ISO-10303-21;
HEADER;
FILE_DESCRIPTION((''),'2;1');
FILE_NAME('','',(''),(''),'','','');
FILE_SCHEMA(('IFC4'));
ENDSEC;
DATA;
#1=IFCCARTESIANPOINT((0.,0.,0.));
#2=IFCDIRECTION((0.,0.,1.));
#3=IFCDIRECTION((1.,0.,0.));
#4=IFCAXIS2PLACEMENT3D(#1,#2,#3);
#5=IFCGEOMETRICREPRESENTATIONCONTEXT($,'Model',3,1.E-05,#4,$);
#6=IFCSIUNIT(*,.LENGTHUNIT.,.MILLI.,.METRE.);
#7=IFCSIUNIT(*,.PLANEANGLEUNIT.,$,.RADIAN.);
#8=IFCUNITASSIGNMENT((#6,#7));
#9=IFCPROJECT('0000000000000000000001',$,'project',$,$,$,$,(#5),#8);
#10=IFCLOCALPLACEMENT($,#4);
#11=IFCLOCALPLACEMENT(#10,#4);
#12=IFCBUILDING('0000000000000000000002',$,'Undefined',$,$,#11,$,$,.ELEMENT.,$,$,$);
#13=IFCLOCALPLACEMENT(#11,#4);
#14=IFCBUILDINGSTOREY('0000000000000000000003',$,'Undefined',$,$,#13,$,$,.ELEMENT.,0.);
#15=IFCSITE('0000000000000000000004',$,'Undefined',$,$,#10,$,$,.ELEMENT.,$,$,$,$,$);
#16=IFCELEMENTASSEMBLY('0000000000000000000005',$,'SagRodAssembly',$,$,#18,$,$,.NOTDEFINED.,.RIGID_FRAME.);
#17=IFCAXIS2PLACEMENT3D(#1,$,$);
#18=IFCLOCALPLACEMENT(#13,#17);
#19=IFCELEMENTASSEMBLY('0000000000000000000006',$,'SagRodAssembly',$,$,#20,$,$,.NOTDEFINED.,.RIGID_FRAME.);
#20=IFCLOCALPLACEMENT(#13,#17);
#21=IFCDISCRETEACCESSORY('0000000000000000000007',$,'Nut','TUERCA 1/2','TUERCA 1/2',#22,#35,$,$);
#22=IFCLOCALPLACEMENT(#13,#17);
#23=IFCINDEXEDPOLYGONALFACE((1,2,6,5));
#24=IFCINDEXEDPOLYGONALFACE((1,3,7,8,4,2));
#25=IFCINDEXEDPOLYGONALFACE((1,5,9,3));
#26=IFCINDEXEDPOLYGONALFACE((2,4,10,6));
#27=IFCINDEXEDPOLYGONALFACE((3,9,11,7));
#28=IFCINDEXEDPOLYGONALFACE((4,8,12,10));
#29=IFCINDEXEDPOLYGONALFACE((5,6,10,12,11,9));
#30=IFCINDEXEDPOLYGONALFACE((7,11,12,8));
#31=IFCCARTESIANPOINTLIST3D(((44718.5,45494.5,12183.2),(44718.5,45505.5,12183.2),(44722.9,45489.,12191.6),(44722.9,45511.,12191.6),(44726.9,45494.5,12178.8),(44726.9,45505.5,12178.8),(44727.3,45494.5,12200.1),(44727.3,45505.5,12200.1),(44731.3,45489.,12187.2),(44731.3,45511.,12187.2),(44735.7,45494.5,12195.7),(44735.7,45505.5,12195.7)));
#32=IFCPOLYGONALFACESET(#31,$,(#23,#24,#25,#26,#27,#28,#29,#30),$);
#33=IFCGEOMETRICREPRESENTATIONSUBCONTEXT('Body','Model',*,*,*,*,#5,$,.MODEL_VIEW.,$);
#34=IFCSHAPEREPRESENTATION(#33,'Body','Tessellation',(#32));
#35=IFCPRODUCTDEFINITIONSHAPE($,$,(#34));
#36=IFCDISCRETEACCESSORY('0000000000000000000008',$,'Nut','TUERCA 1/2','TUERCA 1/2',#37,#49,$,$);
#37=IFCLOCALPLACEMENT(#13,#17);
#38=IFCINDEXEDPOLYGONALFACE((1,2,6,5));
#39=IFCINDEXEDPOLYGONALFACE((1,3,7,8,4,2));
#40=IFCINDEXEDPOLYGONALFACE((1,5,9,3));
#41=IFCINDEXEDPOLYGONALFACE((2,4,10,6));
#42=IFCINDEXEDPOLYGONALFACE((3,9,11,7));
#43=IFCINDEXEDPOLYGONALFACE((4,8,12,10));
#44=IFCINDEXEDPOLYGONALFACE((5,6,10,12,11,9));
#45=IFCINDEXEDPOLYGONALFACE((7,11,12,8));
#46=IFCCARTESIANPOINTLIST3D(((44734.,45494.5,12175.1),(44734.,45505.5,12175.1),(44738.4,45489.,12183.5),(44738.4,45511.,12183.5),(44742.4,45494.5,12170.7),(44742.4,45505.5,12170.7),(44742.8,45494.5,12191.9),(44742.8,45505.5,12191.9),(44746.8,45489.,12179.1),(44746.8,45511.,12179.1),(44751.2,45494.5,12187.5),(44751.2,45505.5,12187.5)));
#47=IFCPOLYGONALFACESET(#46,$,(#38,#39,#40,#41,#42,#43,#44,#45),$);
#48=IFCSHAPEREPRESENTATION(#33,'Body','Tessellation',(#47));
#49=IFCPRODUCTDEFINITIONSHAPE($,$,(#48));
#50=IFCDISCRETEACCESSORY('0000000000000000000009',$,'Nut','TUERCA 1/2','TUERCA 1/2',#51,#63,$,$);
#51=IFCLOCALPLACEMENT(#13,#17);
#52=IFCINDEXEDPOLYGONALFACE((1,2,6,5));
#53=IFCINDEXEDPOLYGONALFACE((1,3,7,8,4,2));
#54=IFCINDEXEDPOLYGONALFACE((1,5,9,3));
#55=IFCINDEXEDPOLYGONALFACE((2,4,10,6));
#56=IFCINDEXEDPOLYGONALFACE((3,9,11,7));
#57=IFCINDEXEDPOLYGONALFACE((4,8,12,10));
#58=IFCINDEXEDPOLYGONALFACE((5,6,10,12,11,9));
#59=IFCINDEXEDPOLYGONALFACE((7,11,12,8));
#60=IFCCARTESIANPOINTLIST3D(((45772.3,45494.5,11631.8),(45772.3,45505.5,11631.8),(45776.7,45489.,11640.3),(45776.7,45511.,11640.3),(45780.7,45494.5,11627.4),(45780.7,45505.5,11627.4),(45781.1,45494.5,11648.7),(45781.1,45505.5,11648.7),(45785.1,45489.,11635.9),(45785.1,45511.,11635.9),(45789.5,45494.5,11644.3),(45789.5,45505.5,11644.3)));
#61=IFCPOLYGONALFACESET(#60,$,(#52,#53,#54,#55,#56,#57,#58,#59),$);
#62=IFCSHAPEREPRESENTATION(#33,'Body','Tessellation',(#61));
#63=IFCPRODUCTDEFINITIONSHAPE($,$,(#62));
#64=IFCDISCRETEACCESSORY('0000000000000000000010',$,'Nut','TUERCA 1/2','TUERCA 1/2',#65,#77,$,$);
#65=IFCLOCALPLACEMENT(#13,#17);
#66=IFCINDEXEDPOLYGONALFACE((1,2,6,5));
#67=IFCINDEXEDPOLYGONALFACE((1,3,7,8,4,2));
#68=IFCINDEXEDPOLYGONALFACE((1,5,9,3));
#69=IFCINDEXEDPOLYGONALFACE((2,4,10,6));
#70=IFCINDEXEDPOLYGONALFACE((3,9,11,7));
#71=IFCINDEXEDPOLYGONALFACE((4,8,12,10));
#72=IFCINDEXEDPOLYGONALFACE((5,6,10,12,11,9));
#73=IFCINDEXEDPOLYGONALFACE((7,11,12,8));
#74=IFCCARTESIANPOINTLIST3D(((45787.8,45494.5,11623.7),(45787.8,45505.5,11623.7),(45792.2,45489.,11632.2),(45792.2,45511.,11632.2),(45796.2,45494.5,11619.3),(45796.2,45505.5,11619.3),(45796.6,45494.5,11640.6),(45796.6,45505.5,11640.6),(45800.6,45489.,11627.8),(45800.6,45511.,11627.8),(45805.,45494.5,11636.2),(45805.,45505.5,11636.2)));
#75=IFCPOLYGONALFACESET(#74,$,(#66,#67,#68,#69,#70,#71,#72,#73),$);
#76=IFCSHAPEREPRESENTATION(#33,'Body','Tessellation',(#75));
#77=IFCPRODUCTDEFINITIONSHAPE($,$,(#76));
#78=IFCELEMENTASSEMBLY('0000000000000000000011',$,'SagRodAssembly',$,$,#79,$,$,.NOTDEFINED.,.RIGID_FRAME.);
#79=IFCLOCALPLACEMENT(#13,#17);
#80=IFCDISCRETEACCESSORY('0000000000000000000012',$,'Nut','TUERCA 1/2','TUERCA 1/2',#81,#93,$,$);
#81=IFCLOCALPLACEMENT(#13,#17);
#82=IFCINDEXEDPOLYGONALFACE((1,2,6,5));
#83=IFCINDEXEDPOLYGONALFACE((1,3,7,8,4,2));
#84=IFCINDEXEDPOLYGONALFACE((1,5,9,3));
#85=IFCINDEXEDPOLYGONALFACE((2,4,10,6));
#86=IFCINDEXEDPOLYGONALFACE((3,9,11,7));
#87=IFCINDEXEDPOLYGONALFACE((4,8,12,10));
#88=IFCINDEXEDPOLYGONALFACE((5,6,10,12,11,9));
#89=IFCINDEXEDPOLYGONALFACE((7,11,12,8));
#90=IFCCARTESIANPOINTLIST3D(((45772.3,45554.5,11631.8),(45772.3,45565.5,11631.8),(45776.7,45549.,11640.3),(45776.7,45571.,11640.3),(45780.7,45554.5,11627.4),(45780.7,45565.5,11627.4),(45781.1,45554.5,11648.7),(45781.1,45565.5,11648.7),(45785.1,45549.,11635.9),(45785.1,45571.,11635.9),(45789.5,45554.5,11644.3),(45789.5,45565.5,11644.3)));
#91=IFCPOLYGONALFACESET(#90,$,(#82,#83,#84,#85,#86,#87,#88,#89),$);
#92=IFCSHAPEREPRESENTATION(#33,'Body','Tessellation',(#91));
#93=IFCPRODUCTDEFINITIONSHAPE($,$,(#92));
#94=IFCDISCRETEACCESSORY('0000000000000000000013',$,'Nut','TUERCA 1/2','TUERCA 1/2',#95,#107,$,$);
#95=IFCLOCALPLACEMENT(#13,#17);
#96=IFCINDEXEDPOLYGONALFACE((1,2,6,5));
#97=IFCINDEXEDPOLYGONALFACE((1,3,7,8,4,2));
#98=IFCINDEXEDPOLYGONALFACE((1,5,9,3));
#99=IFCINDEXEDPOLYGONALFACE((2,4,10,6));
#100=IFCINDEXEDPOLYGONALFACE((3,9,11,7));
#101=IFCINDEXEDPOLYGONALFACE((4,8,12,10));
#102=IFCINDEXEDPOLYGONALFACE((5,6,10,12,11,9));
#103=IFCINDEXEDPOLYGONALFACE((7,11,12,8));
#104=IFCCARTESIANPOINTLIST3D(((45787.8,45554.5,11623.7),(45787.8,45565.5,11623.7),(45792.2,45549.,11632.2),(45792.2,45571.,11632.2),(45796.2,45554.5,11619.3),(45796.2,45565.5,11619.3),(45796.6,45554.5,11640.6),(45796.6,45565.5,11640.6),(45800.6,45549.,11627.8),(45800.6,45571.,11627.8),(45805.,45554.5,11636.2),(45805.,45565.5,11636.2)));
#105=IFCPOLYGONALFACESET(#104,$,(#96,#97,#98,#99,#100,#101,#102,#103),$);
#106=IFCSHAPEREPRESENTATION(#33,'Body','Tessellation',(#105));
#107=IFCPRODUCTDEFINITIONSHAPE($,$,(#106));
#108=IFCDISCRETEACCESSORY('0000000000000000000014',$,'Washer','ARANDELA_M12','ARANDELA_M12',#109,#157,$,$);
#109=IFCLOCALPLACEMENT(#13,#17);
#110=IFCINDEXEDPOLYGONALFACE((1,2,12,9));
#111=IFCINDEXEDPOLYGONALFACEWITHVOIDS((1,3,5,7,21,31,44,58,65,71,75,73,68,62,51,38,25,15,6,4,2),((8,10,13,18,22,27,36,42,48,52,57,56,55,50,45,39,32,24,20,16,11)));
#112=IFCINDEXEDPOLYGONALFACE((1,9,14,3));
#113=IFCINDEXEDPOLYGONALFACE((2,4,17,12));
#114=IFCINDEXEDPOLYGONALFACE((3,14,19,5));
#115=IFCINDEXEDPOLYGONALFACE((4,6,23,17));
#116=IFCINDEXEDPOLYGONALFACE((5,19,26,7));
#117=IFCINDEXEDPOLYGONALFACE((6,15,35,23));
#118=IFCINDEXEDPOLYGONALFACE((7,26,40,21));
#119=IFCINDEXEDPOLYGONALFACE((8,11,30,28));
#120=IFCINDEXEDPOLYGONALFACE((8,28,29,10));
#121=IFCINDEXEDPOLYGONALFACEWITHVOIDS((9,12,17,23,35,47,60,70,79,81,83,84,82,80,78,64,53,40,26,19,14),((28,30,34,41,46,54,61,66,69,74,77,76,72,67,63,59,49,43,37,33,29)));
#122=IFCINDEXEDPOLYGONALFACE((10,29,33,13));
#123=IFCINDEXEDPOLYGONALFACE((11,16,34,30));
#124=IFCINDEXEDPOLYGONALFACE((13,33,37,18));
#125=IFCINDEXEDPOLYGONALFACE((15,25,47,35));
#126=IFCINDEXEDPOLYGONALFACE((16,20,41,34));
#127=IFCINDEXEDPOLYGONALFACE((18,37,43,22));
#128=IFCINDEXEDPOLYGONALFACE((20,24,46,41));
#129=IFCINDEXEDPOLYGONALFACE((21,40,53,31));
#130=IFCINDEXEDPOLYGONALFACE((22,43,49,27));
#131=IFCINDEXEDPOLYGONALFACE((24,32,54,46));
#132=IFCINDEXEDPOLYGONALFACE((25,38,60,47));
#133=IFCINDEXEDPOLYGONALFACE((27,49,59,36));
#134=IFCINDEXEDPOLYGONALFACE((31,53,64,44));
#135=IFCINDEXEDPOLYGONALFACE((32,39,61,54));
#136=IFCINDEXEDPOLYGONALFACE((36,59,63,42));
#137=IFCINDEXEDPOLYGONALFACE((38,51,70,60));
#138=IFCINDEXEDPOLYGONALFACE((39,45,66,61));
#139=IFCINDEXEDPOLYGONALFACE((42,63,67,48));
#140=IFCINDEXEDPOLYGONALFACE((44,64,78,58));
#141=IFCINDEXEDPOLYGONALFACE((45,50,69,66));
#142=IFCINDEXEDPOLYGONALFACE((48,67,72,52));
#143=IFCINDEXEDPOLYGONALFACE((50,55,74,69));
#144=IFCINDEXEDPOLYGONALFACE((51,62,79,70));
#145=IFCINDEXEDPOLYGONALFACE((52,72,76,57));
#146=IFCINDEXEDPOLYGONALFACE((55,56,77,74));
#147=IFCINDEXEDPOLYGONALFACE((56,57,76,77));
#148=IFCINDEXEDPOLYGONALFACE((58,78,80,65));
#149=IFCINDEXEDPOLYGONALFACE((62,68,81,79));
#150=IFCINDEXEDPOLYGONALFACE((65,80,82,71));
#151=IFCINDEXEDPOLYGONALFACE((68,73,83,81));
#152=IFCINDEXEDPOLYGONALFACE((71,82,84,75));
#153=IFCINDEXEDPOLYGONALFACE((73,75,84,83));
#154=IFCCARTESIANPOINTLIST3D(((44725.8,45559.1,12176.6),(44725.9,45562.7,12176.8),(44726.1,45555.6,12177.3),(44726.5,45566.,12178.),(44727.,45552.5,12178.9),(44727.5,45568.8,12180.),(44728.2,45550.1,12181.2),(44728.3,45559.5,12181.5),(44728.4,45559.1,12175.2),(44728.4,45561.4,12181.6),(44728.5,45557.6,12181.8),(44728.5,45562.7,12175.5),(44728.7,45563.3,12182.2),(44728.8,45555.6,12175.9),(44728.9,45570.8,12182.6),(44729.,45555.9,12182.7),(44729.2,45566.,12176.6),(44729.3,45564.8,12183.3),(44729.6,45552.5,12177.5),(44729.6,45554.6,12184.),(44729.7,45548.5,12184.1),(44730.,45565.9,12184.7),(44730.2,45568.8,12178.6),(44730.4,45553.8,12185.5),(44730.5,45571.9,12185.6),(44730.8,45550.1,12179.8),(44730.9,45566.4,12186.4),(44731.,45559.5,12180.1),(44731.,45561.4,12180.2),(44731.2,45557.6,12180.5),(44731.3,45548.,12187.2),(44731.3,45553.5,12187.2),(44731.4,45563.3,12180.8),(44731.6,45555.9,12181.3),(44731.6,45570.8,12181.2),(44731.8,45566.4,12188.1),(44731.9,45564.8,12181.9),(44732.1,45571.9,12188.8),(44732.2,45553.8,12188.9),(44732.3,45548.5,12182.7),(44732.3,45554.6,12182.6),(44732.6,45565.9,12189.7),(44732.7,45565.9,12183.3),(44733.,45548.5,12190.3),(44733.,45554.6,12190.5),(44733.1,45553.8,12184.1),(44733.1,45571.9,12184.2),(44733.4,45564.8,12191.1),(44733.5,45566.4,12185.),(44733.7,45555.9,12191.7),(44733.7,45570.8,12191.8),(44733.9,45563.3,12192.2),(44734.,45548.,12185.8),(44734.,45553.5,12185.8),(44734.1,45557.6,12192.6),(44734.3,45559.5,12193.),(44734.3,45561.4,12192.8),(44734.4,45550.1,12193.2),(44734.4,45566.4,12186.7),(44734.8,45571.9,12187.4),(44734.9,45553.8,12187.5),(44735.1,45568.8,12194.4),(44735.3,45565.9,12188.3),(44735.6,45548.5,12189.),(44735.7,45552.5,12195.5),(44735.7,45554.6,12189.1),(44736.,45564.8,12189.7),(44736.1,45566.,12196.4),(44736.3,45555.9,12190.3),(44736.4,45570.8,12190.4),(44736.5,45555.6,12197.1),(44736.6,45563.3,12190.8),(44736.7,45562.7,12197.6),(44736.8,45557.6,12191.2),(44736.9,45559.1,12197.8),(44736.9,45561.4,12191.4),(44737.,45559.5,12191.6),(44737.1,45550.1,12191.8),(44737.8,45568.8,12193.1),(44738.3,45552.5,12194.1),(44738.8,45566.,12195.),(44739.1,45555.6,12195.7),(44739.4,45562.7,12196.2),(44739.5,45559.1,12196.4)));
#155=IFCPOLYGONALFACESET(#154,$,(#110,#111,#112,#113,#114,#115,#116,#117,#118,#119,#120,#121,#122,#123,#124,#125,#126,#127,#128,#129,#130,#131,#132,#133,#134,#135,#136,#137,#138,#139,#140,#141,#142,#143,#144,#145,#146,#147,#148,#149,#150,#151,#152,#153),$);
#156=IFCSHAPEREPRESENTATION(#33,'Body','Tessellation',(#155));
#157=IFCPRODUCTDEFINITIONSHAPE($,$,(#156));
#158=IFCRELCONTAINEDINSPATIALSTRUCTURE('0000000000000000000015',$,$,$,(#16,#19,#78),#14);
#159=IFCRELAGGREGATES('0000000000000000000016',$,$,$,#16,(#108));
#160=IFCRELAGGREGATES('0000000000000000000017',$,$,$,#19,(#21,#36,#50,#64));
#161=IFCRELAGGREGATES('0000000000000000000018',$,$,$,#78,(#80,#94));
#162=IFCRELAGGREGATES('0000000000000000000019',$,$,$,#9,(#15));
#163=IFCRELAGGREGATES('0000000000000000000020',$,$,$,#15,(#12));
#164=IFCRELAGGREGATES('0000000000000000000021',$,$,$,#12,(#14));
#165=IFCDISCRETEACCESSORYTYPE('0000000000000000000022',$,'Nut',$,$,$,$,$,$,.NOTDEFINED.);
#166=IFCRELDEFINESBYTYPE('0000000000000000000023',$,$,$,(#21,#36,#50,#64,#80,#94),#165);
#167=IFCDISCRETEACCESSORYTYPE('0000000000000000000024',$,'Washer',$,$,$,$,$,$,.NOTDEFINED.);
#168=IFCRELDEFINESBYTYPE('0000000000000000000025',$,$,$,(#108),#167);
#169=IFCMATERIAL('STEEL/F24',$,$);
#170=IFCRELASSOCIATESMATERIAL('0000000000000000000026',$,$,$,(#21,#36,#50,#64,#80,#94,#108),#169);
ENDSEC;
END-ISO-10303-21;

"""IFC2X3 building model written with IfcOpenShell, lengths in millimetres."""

from ifc_helpers import new_model, si_unit, frame, origin_with_axes, origin_2d_with_axis, place, context, subcontext, project, spatial, polyline, hollow_circle, outline, extrude, material, type_object, element, aggregate, save


model = new_model("IFC2X3")

# Units and contexts
model_context = context("Model", 3, precision=1e-05, world=origin_with_axes())
body_context = subcontext(model_context, "Body", "Model", "MODEL_VIEW")
ifc_project = project(units=[si_unit("LENGTHUNIT", "METRE", prefix="MILLI"), si_unit("PLANEANGLEUNIT", "RADIAN")], contexts=[model_context])

# Site, building, storey
site_placement = place(None, origin_with_axes())
site = spatial("IfcSite", under=ifc_project, at=site_placement, Name="Undefined", CompositionType="ELEMENT")
building_placement = place(site_placement, origin_with_axes())
building = spatial("IfcBuilding", under=site, at=building_placement, Name="Undefined", CompositionType="ELEMENT")
storey_placement = place(building_placement, origin_with_axes())
storey = spatial("IfcBuildingStorey", under=building, at=storey_placement, Name="Undefined", CompositionType="ELEMENT", Elevation=0.0)

# Element assemblies
assembly_1_placement = place(storey_placement, origin_with_axes())
assembly_1 = element("IfcElementAssembly", 1, at=assembly_1_placement, inside=storey, Name="SagRodAssembly", AssemblyPlace="NOTDEFINED", PredefinedType="RIGID_FRAME")
ifc_material_1 = material(Name="STEEL/F24")
assembly_2_placement = place(storey_placement, origin_with_axes())
assembly_2 = element("IfcElementAssembly", 2, at=assembly_2_placement, inside=storey, Name="SagRodAssembly", AssemblyPlace="NOTDEFINED", PredefinedType="RIGID_FRAME")

# Discrete accessories
discrete_accessory_type_1 = type_object("IfcDiscreteAccessoryType", Name="Nut")
discrete_accessory_1_placement = place(assembly_2_placement, frame((44731.3, 45500.0, 12187.2), z_axis=(-0.463578, 0.0, -0.886056), x_axis=(-0.886056, 0.0, 0.463578)))
discrete_accessory_1 = element("IfcDiscreteAccessory", 3, at=discrete_accessory_1_placement, type_object=discrete_accessory_type_1, material=ifc_material_1, Name="Nut", Description="TUERCA 1/2", ObjectType="TUERCA 1/2", context=body_context, shape_type="SweptSolid", body=[
    extrude(outline(polyline([(-5.5, 9.5), (5.5, 9.5), (11.0, 0.0), (5.5, -9.5), (-5.5, -9.5), (-11.0, 0.0), (-5.5, 9.5)])), frame((9.5, 0.0, 0.0), z_axis=(-1.0, 0.0, 0.0), x_axis=(0.0, -1.0, 0.0)), (0.0, 0.0, 1.0), 9.5),
])
discrete_accessory_2_placement = place(assembly_2_placement, frame((44746.8, 45500.0, 12179.1), z_axis=(-0.463578, 0.0, -0.886056), x_axis=(-0.886056, 0.0, 0.463578)))
discrete_accessory_2 = element("IfcDiscreteAccessory", 4, at=discrete_accessory_2_placement, type_object=discrete_accessory_type_1, material=ifc_material_1, Name="Nut", Description="TUERCA 1/2", ObjectType="TUERCA 1/2", context=body_context, shape_type="SweptSolid", body=[
    extrude(outline(polyline([(-5.5, 9.5), (5.5, 9.5), (11.0, 0.0), (5.5, -9.5), (-5.5, -9.5), (-11.0, 0.0), (-5.5, 9.5)])), frame((9.5, 0.0, 0.0), z_axis=(-1.0, 0.0, 0.0), x_axis=(0.0, -1.0, 0.0)), (0.0, 0.0, 1.0), 9.5),
])
discrete_accessory_3_placement = place(assembly_2_placement, frame((45785.1, 45500.0, 11635.9), z_axis=(-0.463578, 0.0, -0.886056), x_axis=(-0.886056, 0.0, 0.463578)))
discrete_accessory_3 = element("IfcDiscreteAccessory", 5, at=discrete_accessory_3_placement, type_object=discrete_accessory_type_1, material=ifc_material_1, Name="Nut", Description="TUERCA 1/2", ObjectType="TUERCA 1/2", context=body_context, shape_type="SweptSolid", body=[
    extrude(outline(polyline([(-5.5, 9.5), (5.5, 9.5), (11.0, 0.0), (5.5, -9.5), (-5.5, -9.5), (-11.0, 0.0), (-5.5, 9.5)])), frame((9.5, 0.0, 0.0), z_axis=(-1.0, 0.0, 0.0), x_axis=(0.0, -1.0, 0.0)), (0.0, 0.0, 1.0), 9.5),
])
discrete_accessory_4_placement = place(assembly_2_placement, frame((45800.6, 45500.0, 11627.8), z_axis=(-0.463578, 0.0, -0.886056), x_axis=(-0.886056, 0.0, 0.463578)))
discrete_accessory_4 = element("IfcDiscreteAccessory", 6, at=discrete_accessory_4_placement, type_object=discrete_accessory_type_1, material=ifc_material_1, Name="Nut", Description="TUERCA 1/2", ObjectType="TUERCA 1/2", context=body_context, shape_type="SweptSolid", body=[
    extrude(outline(polyline([(-5.5, 9.5), (5.5, 9.5), (11.0, 0.0), (5.5, -9.5), (-5.5, -9.5), (-11.0, 0.0), (-5.5, 9.5)])), frame((9.5, 0.0, 0.0), z_axis=(-1.0, 0.0, 0.0), x_axis=(0.0, -1.0, 0.0)), (0.0, 0.0, 1.0), 9.5),
])

# Element assembly, discrete accessories
assembly_3_placement = place(storey_placement, origin_with_axes())
assembly_3 = element("IfcElementAssembly", 7, at=assembly_3_placement, inside=storey, Name="SagRodAssembly", AssemblyPlace="NOTDEFINED", PredefinedType="RIGID_FRAME")
discrete_accessory_5_placement = place(assembly_3_placement, frame((45785.1, 45560.0, 11635.9), z_axis=(-0.463578, 0.0, -0.886056), x_axis=(-0.886056, 0.0, 0.463578)))
discrete_accessory_5 = element("IfcDiscreteAccessory", 8, at=discrete_accessory_5_placement, type_object=discrete_accessory_type_1, material=ifc_material_1, Name="Nut", Description="TUERCA 1/2", ObjectType="TUERCA 1/2", context=body_context, shape_type="SweptSolid", body=[
    extrude(outline(polyline([(-5.5, 9.5), (5.5, 9.5), (11.0, 0.0), (5.5, -9.5), (-5.5, -9.5), (-11.0, 0.0), (-5.5, 9.5)])), frame((9.5, 0.0, 0.0), z_axis=(-1.0, 0.0, 0.0), x_axis=(0.0, -1.0, 0.0)), (0.0, 0.0, 1.0), 9.5),
])
discrete_accessory_6_placement = place(assembly_3_placement, frame((45800.6, 45560.0, 11627.8), z_axis=(-0.463578, 0.0, -0.886056), x_axis=(-0.886056, 0.0, 0.463578)))
discrete_accessory_6 = element("IfcDiscreteAccessory", 9, at=discrete_accessory_6_placement, type_object=discrete_accessory_type_1, material=ifc_material_1, Name="Nut", Description="TUERCA 1/2", ObjectType="TUERCA 1/2", context=body_context, shape_type="SweptSolid", body=[
    extrude(outline(polyline([(-5.5, 9.5), (5.5, 9.5), (11.0, 0.0), (5.5, -9.5), (-5.5, -9.5), (-11.0, 0.0), (-5.5, 9.5)])), frame((9.5, 0.0, 0.0), z_axis=(-1.0, 0.0, 0.0), x_axis=(0.0, -1.0, 0.0)), (0.0, 0.0, 1.0), 9.5),
])

# Discrete accessory
discrete_accessory_type_2 = type_object("IfcDiscreteAccessoryType", Name="Washer")
discrete_accessory_7_placement = place(assembly_1_placement, frame((44734.0, 45560.0, 12185.8), z_axis=(-0.463578, 0.0, -0.886056), x_axis=(-0.886056, 0.0, 0.463578)))
discrete_accessory_7 = element("IfcDiscreteAccessory", 10, at=discrete_accessory_7_placement, type_object=discrete_accessory_type_2, material=ifc_material_1, Name="Washer", Description="ARANDELA_M12", ObjectType="ARANDELA_M12", context=body_context, shape_type="SweptSolid", body=[
    extrude(hollow_circle(Radius=12.0, WallThickness=5.5, at=origin_2d_with_axis()), frame((3.0, 0.0, 0.0), z_axis=(-1.0, 0.0, 0.0), x_axis=(0.0, -1.0, 0.0)), (0.0, 0.0, 1.0), 3.0),
])
aggregate(assembly_1, [discrete_accessory_7])
aggregate(assembly_2, [discrete_accessory_1, discrete_accessory_2, discrete_accessory_3, discrete_accessory_4])
aggregate(assembly_3, [discrete_accessory_5, discrete_accessory_6])

save(model, "model.ifc")
